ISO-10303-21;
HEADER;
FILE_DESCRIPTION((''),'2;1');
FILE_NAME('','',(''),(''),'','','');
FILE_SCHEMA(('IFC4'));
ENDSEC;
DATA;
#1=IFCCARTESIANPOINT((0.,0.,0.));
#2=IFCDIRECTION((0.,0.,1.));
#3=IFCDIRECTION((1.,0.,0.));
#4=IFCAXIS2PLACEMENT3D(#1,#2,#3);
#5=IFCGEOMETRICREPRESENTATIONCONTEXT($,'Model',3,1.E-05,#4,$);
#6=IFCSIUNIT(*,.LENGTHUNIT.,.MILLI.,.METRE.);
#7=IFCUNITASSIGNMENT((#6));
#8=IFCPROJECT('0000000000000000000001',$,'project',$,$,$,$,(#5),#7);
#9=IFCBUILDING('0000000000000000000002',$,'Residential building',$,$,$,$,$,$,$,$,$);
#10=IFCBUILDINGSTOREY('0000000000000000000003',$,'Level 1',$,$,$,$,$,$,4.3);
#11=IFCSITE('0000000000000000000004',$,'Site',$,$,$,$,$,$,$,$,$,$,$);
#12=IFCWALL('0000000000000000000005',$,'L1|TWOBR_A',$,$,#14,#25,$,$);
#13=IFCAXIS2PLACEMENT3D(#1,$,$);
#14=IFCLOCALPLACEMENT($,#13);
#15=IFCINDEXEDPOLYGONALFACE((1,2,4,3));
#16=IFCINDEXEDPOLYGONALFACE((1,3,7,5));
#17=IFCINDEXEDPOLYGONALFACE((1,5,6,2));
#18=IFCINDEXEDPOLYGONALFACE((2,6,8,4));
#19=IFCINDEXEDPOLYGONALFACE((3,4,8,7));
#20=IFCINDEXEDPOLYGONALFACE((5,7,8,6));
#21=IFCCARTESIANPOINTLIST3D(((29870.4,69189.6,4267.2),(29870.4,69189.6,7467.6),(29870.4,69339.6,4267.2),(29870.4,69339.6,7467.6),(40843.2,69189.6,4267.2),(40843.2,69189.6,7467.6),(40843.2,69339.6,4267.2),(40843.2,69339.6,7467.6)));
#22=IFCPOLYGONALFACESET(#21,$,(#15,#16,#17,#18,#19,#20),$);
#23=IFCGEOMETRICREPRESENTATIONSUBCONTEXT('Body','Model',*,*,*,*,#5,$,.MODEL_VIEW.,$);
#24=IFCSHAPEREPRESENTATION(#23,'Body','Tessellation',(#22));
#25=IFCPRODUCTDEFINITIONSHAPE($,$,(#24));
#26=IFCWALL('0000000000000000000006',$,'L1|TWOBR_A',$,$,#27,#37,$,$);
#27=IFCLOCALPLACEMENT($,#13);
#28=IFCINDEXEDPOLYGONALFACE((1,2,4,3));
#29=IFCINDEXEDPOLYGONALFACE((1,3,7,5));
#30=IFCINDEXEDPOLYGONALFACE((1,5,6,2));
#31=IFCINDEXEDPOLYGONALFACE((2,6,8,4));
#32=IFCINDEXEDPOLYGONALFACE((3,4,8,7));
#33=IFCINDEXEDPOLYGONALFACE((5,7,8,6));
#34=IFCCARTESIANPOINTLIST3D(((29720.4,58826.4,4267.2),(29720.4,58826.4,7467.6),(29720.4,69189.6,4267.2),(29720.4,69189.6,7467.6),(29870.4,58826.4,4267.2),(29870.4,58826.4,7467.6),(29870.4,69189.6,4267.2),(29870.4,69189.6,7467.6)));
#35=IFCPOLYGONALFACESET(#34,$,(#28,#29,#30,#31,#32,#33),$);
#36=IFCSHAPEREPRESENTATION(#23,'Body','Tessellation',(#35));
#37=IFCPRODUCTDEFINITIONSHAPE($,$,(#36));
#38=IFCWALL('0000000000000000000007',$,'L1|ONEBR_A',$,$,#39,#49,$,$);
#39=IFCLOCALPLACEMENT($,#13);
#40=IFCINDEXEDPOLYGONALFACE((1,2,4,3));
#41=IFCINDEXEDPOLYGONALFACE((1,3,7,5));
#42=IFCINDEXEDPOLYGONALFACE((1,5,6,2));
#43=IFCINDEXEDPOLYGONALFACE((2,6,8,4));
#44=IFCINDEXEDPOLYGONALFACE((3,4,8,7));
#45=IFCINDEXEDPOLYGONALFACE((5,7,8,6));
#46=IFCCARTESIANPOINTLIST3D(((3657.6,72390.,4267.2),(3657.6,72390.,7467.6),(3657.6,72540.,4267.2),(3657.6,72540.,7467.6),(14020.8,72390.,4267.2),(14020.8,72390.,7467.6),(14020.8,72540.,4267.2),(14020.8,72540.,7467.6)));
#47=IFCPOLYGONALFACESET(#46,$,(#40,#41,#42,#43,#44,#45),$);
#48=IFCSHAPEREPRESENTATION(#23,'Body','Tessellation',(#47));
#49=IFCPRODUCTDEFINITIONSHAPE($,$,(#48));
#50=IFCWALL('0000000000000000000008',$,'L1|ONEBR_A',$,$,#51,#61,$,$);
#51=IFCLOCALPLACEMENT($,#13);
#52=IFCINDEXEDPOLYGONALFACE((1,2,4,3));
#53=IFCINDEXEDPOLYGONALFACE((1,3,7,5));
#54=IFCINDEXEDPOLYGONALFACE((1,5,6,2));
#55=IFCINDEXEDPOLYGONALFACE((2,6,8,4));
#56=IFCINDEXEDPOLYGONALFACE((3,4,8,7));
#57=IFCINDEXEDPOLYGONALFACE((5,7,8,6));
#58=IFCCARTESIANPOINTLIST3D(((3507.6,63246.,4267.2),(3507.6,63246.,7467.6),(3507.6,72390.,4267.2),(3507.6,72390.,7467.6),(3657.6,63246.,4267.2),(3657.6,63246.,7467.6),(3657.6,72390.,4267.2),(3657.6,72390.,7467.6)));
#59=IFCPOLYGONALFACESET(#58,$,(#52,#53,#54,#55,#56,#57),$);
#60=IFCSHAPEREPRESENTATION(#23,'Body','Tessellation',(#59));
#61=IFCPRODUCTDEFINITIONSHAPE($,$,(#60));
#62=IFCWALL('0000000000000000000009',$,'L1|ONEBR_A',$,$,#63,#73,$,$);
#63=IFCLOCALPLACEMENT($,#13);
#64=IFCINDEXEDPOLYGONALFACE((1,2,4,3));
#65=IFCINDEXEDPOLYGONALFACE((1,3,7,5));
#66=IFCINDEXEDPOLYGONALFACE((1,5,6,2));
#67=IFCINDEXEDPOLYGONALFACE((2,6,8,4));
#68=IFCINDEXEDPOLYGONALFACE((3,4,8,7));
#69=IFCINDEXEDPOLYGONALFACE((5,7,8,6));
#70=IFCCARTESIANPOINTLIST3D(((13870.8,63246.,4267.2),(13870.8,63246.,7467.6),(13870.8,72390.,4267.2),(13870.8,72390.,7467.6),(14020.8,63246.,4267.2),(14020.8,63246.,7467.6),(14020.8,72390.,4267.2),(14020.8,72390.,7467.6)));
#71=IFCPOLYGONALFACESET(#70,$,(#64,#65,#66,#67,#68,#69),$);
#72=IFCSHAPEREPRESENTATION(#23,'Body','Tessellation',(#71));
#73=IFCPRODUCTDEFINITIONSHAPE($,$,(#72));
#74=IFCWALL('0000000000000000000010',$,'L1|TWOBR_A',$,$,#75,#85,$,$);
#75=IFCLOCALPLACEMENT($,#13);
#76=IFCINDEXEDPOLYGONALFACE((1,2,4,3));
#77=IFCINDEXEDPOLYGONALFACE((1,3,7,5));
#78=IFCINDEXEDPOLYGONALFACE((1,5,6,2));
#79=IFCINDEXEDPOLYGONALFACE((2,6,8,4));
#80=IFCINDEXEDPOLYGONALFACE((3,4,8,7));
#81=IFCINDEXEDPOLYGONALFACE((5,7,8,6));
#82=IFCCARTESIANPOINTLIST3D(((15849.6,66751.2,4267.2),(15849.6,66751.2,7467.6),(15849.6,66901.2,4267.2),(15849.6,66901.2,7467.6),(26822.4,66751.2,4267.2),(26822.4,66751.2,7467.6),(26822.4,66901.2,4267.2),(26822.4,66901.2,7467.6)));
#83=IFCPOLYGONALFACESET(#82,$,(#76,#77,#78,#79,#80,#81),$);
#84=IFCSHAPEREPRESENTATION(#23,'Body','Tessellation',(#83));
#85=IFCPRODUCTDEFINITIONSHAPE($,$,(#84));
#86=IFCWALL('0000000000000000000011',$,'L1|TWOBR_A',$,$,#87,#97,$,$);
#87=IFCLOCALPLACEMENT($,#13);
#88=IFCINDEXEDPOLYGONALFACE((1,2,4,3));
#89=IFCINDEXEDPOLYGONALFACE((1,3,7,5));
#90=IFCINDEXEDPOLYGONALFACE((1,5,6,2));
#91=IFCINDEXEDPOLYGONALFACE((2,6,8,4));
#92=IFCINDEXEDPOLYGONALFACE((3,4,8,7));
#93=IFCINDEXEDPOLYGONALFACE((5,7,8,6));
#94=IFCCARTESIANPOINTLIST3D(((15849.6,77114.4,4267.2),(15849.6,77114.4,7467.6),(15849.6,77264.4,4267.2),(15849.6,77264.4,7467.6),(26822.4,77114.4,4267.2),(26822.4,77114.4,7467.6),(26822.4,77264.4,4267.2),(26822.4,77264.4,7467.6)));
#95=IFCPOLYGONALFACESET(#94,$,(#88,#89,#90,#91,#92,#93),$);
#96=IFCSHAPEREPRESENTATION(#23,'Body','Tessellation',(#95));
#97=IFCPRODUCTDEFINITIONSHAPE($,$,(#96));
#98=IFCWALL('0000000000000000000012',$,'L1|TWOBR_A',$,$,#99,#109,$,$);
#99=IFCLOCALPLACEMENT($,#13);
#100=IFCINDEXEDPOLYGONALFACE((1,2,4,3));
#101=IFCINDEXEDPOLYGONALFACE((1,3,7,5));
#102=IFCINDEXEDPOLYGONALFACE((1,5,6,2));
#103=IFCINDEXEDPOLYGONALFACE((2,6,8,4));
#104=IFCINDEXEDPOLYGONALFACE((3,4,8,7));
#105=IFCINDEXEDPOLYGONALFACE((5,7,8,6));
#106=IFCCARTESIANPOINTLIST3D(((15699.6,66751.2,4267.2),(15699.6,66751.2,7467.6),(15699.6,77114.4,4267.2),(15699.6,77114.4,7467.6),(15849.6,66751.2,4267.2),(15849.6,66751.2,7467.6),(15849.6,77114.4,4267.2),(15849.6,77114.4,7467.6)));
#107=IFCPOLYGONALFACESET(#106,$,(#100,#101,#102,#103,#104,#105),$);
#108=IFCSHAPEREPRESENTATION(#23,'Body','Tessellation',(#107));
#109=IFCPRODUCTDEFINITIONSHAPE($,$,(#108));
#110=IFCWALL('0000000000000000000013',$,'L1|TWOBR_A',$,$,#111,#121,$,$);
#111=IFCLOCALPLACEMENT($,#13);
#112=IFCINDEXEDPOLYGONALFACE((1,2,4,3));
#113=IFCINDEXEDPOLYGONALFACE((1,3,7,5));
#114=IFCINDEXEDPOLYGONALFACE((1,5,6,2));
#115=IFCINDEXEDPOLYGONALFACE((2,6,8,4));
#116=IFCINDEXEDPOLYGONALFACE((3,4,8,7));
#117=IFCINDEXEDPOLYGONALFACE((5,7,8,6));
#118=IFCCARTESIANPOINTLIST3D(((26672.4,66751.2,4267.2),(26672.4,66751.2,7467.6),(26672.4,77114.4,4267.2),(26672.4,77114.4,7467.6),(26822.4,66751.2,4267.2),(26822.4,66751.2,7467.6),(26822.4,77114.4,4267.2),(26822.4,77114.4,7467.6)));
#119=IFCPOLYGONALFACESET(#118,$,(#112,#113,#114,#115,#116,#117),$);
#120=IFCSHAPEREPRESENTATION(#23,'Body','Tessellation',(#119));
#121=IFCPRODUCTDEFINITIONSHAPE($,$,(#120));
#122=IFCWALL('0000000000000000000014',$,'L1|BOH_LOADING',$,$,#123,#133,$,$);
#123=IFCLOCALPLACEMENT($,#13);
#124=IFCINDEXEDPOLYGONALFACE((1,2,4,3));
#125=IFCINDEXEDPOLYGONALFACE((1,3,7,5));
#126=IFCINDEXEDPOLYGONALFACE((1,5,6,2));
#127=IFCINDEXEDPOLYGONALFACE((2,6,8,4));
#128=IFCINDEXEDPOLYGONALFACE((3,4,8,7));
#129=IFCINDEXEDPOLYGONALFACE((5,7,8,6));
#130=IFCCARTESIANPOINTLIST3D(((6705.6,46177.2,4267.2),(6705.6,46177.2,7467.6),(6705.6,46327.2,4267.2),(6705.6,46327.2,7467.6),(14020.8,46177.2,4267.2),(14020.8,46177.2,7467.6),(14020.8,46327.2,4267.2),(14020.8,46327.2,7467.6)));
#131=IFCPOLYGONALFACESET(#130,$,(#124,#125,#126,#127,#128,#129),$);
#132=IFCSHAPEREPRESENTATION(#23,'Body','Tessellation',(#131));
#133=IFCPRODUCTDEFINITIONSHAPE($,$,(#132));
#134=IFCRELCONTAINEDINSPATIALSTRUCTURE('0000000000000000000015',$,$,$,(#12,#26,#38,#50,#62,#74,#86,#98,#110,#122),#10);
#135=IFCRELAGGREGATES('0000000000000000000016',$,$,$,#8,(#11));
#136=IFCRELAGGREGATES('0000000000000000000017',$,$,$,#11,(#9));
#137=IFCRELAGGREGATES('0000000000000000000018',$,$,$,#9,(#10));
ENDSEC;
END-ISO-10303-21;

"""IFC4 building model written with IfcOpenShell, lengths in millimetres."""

from ifc_helpers import new_model, si_unit, frame, origin_with_axes, place, context, subcontext, project, spatial, indexed_curve, outline, extrude, element, save


model = new_model("IFC4")

# Units and contexts
model_context = context("Model", 3, precision=1e-05, world=origin_with_axes())
body_context = subcontext(model_context, "Body", "Model", "MODEL_VIEW")
ifc_project = project(units=[si_unit("LENGTHUNIT", "METRE", prefix="MILLI")], contexts=[model_context])

# Site, building, storey
site = spatial("IfcSite", under=ifc_project, Name="Site")
building = spatial("IfcBuilding", under=site, Name="Residential building")
storey = spatial("IfcBuildingStorey", under=building, Name="Level 1", Elevation=4.3)

# Walls
for number, where, z_axis, x_axis, name in (
    (1, (29870.4, 69189.6, 4267.2), (0.0, 0.0, 1.0), (1.0, 0.0, 0.0), "L1|TWOBR_A"),
):
    element("IfcWall", number, at=place(None, frame(where, z_axis=z_axis, x_axis=x_axis)), inside=storey, Name=name, context=body_context, shape_type="SweptSolid", body=[
        extrude(outline(indexed_curve([(0.0, 0.0), (0.0, 150.0), (10972.8, 150.0), (10972.8, 0.0), (0.0, 0.0)], self_intersect=False)), origin_with_axes(), (0.0, 0.0, 1.0), 3200.4),
    ])
for number, where, z_axis, x_axis, name in (
    (2, (29870.4, 58826.4, 4267.2), (0.0, 0.0, 1.0), (0.0, 1.0, 0.0), "L1|TWOBR_A"),
    (3, (3657.6, 72390.0, 4267.2), (0.0, 0.0, 1.0), (1.0, 0.0, 0.0), "L1|ONEBR_A"),
):
    element("IfcWall", number, at=place(None, frame(where, z_axis=z_axis, x_axis=x_axis)), inside=storey, Name=name, context=body_context, shape_type="SweptSolid", body=[
        extrude(outline(indexed_curve([(0.0, 0.0), (0.0, 150.0), (10363.2, 150.0), (10363.2, 0.0), (0.0, 0.0)], self_intersect=False)), origin_with_axes(), (0.0, 0.0, 1.0), 3200.4),
    ])
for number, where, z_axis, x_axis, name in (
    (4, (3657.6, 63246.0, 4267.2), (0.0, 0.0, 1.0), (0.0, 1.0, 0.0), "L1|ONEBR_A"),
    (5, (14020.8, 63246.0, 4267.2), (0.0, 0.0, 1.0), (0.0, 1.0, 0.0), "L1|ONEBR_A"),
):
    element("IfcWall", number, at=place(None, frame(where, z_axis=z_axis, x_axis=x_axis)), inside=storey, Name=name, context=body_context, shape_type="SweptSolid", body=[
        extrude(outline(indexed_curve([(0.0, 0.0), (0.0, 150.0), (9144.0, 150.0), (9144.0, 0.0), (0.0, 0.0)], self_intersect=False)), origin_with_axes(), (0.0, 0.0, 1.0), 3200.4),
    ])
for number, where, z_axis, x_axis, name in (
    (6, (15849.6, 66751.2, 4267.2), (0.0, 0.0, 1.0), (1.0, 0.0, 0.0), "L1|TWOBR_A"),
    (7, (15849.6, 77114.4, 4267.2), (0.0, 0.0, 1.0), (1.0, 0.0, 0.0), "L1|TWOBR_A"),
):
    element("IfcWall", number, at=place(None, frame(where, z_axis=z_axis, x_axis=x_axis)), inside=storey, Name=name, context=body_context, shape_type="SweptSolid", body=[
        extrude(outline(indexed_curve([(0.0, 0.0), (0.0, 150.0), (10972.8, 150.0), (10972.8, 0.0), (0.0, 0.0)], self_intersect=False)), origin_with_axes(), (0.0, 0.0, 1.0), 3200.4),
    ])
for number, where, z_axis, x_axis, name in (
    (8, (15849.6, 66751.2, 4267.2), (0.0, 0.0, 1.0), (0.0, 1.0, 0.0), "L1|TWOBR_A"),
    (9, (26822.4, 66751.2, 4267.2), (0.0, 0.0, 1.0), (0.0, 1.0, 0.0), "L1|TWOBR_A"),
):
    element("IfcWall", number, at=place(None, frame(where, z_axis=z_axis, x_axis=x_axis)), inside=storey, Name=name, context=body_context, shape_type="SweptSolid", body=[
        extrude(outline(indexed_curve([(0.0, 0.0), (0.0, 150.0), (10363.2, 150.0), (10363.2, 0.0), (0.0, 0.0)], self_intersect=False)), origin_with_axes(), (0.0, 0.0, 1.0), 3200.4),
    ])
wall_1_placement = place(None, frame((6705.6, 46177.2, 4267.2), z_axis=(0.0, 0.0, 1.0), x_axis=(1.0, 0.0, 0.0)))
element("IfcWall", 10, at=wall_1_placement, inside=storey, Name="L1|BOH_LOADING", context=body_context, shape_type="SweptSolid", body=[
    extrude(outline(indexed_curve([(0.0, 0.0), (0.0, 150.0), (7315.2, 150.0), (7315.2, 0.0), (0.0, 0.0)], self_intersect=False)), origin_with_axes(), (0.0, 0.0, 1.0), 3200.4),
])

save(model, "model.ifc")
